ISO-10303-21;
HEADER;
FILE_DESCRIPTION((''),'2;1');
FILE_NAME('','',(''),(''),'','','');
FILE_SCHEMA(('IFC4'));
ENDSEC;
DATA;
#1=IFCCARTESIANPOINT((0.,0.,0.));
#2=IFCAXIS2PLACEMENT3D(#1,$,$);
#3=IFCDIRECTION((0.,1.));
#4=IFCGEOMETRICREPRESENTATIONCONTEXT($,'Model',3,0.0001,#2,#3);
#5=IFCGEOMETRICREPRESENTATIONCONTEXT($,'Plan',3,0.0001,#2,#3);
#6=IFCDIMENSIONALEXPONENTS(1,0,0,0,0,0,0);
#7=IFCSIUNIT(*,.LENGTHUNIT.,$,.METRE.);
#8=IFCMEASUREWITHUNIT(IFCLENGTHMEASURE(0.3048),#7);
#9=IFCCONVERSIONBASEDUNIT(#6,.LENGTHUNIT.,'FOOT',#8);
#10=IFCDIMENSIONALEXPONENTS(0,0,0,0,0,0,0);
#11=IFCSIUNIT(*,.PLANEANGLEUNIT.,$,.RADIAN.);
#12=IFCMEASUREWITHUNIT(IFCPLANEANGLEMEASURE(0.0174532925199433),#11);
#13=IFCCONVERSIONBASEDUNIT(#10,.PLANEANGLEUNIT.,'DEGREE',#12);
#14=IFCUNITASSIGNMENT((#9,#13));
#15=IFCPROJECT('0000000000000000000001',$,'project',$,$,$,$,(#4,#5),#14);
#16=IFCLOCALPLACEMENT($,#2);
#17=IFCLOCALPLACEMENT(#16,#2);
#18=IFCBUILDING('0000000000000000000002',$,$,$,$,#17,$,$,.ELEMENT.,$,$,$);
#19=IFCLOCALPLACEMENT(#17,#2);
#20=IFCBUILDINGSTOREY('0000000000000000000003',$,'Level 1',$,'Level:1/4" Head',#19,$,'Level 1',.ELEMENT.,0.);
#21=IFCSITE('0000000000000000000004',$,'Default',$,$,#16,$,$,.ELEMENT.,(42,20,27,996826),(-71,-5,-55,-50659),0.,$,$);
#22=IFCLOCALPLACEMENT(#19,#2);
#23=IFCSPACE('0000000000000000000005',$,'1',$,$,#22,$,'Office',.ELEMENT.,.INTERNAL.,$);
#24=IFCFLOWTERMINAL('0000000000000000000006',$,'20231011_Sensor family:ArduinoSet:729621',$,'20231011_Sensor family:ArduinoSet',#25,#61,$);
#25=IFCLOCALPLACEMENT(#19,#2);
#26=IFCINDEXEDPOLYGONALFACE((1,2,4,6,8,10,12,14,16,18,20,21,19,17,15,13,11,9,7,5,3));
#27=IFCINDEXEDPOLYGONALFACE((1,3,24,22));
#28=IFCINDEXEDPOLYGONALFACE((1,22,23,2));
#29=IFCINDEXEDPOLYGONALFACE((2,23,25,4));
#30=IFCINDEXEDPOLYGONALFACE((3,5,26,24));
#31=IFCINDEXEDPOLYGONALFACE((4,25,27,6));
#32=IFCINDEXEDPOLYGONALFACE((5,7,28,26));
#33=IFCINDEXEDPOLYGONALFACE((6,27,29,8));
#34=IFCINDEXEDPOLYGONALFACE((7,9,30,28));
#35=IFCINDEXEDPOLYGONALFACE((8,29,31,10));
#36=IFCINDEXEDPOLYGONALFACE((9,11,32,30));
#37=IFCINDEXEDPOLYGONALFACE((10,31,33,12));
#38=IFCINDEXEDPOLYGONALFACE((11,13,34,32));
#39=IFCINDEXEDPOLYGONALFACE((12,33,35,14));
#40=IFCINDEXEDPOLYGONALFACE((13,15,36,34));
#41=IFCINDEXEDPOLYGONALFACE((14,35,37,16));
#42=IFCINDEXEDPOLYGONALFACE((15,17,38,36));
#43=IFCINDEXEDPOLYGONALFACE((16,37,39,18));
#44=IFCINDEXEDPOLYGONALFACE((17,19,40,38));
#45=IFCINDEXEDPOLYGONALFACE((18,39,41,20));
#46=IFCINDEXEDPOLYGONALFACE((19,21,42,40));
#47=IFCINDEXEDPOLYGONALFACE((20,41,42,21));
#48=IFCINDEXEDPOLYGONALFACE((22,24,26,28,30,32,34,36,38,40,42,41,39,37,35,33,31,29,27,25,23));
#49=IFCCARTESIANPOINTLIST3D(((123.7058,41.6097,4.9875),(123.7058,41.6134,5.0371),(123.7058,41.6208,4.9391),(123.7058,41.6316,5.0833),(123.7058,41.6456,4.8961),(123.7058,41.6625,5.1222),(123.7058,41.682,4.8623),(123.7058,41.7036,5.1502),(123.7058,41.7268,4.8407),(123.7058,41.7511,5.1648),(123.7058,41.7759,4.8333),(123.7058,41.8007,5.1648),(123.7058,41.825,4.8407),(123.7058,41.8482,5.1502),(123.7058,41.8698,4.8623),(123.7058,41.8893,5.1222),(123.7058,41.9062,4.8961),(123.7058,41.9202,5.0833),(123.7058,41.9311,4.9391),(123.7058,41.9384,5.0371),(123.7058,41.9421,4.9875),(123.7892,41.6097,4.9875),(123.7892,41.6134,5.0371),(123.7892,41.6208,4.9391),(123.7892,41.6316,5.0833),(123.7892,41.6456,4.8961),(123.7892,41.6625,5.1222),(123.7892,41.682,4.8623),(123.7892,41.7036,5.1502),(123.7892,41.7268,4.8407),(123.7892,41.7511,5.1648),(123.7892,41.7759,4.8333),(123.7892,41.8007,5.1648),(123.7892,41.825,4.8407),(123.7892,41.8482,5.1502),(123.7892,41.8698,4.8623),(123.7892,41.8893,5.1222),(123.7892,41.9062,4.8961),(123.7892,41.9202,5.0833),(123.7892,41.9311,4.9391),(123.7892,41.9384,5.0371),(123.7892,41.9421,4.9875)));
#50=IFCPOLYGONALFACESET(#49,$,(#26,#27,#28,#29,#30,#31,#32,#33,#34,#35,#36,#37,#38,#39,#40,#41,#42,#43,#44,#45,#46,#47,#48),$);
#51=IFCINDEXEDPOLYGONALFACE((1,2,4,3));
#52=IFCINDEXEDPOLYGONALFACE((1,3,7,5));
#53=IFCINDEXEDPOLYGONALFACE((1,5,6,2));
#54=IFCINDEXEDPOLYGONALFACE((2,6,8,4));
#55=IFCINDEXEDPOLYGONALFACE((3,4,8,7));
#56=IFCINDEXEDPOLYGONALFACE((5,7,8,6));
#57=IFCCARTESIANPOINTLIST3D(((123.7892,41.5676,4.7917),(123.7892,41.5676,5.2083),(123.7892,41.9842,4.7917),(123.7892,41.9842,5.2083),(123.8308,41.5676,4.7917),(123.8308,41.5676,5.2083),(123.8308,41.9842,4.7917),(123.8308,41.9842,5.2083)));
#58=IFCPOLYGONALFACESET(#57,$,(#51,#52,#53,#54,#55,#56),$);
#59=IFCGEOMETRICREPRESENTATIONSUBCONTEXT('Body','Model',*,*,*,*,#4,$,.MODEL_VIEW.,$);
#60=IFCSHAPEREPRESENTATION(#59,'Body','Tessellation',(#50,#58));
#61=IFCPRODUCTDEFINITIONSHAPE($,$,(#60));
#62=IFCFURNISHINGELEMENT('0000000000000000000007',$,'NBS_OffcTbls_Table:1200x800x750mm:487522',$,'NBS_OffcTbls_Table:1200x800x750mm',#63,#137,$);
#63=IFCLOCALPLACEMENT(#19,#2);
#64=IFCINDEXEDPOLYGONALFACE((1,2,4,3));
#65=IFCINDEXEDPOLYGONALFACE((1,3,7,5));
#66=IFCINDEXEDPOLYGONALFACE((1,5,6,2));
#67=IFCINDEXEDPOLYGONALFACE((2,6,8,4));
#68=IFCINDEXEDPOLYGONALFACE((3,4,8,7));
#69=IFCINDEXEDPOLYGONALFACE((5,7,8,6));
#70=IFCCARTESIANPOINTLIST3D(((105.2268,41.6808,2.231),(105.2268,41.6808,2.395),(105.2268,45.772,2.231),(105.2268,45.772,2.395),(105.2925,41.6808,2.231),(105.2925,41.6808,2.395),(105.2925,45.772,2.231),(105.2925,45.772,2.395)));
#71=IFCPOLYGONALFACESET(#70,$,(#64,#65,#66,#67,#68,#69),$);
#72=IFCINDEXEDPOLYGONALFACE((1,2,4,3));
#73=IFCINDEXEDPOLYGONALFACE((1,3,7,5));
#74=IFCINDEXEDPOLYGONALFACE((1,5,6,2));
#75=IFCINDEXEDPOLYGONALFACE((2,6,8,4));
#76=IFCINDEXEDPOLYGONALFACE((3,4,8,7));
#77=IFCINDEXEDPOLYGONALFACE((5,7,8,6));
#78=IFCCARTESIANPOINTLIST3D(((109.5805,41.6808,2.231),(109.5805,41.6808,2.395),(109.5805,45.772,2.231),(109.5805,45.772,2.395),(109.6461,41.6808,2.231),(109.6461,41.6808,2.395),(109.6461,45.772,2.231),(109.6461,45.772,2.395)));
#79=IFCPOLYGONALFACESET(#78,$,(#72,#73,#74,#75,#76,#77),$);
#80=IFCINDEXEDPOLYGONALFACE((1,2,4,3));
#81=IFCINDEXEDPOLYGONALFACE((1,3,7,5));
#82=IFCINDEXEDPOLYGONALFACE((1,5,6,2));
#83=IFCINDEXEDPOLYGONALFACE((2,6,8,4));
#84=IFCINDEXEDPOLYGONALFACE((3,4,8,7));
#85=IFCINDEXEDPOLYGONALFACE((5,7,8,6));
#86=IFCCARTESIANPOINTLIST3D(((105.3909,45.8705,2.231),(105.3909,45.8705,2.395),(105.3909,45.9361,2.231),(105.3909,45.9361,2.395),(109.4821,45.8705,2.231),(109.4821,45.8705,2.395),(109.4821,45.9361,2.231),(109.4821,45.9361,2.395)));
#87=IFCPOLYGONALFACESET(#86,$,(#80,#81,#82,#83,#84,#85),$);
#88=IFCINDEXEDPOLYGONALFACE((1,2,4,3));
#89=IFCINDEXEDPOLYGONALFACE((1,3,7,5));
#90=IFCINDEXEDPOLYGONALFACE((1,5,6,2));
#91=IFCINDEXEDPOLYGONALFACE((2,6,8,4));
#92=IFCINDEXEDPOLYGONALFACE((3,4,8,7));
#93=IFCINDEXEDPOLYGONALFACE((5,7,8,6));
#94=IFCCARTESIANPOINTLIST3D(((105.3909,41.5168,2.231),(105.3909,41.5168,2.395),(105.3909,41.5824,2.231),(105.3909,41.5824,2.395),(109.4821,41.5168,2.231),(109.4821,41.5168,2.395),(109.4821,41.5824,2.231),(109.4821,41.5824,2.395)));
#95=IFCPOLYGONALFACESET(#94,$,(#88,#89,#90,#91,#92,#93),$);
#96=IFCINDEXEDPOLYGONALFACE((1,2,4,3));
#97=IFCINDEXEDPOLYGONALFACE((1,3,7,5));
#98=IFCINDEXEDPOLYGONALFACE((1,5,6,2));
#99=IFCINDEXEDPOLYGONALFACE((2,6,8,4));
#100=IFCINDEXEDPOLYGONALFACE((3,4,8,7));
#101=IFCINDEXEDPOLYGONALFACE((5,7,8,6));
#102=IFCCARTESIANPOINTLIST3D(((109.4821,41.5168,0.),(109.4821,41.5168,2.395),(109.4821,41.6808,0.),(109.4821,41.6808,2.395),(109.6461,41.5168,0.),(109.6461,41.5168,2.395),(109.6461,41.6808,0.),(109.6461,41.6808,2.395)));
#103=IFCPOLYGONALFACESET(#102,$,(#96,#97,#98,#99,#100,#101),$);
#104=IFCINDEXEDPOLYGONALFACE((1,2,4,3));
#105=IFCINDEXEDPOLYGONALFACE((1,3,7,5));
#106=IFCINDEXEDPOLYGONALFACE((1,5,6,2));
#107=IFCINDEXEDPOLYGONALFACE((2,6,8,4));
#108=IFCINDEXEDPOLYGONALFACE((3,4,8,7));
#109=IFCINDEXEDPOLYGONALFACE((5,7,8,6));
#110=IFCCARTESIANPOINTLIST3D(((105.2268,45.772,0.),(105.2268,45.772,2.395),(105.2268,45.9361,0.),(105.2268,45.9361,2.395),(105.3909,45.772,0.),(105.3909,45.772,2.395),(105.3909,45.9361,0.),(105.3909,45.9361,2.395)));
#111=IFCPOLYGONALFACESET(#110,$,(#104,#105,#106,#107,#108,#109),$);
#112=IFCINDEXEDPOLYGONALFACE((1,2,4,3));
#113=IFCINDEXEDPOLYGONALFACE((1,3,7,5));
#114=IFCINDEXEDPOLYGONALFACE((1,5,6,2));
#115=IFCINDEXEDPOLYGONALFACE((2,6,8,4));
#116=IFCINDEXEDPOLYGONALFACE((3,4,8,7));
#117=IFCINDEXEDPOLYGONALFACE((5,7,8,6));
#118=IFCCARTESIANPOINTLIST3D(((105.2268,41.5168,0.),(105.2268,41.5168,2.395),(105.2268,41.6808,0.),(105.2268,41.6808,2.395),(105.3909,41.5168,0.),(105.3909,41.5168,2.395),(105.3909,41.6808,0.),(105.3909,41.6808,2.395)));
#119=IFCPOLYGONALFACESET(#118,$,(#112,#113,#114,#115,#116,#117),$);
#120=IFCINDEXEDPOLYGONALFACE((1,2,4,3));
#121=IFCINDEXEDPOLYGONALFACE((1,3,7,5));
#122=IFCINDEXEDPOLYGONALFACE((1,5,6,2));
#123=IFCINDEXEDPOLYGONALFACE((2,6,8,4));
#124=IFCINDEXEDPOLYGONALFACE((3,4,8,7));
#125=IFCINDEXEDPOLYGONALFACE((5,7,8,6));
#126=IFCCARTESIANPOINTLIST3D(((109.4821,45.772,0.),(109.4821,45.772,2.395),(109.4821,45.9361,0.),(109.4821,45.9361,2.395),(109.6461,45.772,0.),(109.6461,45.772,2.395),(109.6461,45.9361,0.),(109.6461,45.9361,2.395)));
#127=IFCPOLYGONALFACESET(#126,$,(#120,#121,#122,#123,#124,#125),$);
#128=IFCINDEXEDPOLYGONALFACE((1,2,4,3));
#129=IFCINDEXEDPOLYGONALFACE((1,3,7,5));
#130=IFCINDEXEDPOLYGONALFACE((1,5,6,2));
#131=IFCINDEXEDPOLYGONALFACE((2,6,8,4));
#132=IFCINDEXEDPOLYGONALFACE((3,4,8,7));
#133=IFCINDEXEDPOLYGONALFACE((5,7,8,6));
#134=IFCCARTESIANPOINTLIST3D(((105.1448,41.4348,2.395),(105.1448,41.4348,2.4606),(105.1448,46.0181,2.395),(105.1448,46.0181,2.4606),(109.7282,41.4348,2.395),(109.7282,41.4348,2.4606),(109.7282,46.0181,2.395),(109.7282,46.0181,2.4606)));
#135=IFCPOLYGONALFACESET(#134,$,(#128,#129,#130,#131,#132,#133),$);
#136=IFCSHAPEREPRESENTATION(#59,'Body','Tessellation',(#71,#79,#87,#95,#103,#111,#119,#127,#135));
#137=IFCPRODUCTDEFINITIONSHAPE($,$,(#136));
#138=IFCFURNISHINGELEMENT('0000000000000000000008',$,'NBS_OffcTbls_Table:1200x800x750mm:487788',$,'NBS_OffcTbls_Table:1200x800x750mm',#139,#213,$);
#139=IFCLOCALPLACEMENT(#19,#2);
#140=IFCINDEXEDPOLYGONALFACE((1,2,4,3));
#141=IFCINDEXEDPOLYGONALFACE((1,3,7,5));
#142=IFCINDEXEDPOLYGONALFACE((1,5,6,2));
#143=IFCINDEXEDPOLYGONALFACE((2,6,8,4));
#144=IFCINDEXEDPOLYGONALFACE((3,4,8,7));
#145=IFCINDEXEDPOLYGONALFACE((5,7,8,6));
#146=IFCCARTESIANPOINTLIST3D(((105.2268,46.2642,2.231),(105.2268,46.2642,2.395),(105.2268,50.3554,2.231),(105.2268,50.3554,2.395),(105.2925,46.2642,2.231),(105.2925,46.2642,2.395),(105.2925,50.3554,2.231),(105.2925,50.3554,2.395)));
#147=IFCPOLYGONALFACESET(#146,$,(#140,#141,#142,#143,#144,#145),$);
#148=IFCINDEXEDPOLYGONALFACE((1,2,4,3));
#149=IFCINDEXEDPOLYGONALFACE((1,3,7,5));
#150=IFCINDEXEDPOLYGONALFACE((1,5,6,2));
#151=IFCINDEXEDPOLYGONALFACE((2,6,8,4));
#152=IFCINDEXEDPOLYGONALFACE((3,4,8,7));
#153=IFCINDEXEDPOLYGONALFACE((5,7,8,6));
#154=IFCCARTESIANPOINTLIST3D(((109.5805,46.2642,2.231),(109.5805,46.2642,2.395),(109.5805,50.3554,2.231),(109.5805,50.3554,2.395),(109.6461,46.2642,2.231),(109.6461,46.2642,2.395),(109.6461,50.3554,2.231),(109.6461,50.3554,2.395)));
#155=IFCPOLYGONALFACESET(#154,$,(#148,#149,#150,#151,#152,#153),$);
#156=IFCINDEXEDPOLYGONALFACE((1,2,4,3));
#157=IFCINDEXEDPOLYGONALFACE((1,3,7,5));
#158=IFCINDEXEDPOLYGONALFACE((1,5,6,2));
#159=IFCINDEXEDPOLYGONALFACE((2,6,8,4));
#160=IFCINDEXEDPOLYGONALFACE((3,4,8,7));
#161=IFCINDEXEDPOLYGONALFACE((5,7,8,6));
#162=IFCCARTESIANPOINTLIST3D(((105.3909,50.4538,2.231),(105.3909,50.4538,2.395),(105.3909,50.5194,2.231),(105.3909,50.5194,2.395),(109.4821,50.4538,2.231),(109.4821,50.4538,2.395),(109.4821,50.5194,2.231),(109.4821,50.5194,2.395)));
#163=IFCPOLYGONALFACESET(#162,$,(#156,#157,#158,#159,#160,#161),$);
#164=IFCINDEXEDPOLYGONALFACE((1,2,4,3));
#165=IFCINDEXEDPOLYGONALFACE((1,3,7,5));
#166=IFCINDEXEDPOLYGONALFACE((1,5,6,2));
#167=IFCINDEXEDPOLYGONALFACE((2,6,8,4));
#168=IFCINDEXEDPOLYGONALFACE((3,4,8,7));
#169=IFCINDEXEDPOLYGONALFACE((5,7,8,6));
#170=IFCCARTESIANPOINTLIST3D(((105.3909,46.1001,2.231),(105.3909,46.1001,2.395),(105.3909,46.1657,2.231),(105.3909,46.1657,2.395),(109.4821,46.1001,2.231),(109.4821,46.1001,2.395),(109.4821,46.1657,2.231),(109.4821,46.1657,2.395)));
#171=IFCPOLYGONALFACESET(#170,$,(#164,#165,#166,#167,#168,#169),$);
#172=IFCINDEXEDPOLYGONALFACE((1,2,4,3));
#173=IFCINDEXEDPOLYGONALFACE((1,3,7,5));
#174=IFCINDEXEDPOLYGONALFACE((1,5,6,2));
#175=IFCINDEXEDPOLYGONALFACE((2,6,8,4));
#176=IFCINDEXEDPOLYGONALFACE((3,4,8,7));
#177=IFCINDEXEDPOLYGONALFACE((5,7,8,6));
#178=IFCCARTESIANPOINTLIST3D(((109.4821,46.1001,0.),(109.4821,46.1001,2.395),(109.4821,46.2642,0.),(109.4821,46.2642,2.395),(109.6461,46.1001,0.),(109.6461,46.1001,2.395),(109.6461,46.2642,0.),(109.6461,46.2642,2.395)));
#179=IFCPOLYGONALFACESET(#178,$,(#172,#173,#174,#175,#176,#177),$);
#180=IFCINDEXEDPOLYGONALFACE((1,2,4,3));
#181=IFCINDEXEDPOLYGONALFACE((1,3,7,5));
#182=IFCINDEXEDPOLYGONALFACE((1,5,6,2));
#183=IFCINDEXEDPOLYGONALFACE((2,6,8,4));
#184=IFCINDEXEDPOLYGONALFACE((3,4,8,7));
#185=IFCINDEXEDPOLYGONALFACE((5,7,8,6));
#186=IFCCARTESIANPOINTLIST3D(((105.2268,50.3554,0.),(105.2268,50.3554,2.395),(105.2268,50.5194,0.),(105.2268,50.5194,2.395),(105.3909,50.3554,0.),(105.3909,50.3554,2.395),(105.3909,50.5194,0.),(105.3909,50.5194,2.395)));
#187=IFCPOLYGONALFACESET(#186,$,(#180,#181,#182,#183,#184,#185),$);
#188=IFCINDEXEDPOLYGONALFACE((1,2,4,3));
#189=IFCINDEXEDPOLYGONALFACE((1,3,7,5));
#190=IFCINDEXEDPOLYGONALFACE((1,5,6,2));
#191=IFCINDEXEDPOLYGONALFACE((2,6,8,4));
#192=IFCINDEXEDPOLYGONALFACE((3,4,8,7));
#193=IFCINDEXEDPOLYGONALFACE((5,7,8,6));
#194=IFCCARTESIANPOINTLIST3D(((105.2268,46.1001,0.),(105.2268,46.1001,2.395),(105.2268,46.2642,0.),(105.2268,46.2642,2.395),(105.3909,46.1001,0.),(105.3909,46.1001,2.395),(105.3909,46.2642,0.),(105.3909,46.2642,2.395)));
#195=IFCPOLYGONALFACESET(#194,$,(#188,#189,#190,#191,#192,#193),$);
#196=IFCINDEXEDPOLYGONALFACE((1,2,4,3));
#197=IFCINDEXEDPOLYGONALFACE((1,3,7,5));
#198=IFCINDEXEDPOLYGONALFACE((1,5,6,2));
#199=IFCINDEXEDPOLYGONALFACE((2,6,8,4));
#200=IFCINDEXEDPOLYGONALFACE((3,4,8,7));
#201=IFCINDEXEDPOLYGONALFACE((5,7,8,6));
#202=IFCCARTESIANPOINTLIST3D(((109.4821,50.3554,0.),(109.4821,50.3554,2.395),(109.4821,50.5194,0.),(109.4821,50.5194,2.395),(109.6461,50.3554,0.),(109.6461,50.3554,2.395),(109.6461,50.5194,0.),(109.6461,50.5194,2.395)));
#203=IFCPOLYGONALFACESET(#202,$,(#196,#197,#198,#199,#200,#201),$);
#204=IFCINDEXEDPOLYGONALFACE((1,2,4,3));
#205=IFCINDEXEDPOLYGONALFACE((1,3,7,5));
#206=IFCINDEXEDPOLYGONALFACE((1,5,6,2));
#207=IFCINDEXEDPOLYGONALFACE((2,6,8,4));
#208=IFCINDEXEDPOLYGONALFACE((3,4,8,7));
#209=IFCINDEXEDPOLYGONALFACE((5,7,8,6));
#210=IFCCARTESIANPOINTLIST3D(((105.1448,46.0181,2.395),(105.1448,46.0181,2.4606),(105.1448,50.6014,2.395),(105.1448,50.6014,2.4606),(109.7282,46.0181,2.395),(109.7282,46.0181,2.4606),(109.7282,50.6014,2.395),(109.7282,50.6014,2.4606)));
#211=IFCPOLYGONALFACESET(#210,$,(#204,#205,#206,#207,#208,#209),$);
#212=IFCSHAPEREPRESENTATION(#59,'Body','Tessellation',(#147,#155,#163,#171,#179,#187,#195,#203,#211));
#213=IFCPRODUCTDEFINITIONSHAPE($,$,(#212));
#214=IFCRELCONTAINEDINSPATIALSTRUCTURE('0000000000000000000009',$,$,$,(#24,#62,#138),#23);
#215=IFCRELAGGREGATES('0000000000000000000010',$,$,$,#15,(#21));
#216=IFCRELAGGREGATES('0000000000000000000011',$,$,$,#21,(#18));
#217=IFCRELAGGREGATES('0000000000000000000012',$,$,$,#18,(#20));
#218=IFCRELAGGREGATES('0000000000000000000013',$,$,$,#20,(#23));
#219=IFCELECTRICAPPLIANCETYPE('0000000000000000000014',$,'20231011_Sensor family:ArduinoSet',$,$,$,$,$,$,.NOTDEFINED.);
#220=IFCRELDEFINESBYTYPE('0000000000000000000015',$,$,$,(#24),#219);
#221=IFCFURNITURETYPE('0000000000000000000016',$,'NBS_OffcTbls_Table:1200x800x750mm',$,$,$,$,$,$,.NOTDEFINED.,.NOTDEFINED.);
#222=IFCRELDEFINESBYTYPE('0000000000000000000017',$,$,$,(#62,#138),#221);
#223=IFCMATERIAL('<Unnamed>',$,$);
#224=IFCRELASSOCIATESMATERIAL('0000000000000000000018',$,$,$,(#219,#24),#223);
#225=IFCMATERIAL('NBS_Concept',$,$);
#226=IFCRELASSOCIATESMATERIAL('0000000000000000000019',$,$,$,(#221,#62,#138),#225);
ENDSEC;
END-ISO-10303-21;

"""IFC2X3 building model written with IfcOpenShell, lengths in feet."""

from ifc_helpers import new_model, entity, si_unit, converted_unit, direction, frame, frame_2d, origin, origin_2d_with_axis, place, context, subcontext, project, spatial, rectangle, circle, extrude, source, transform, mapped, material, type_object, type_shapes, element, save


model = new_model("IFC2X3")

# Units and contexts
model_context = context("Model", 3, precision=0.0001, world=origin(), true_north=direction((0.0, 1.0)))
plan_context = context("Plan", 3, precision=0.0001, world=origin(), true_north=direction((0.0, 1.0)))
body_context = subcontext(model_context, "Body", "Model", "MODEL_VIEW")
ifc_project = project(units=[converted_unit("LENGTHUNIT", "FOOT", entity("IfcLengthMeasure", 0.3048), si_unit("LENGTHUNIT", "METRE"), dimensions=[1, 0, 0, 0, 0, 0, 0]), converted_unit("PLANEANGLEUNIT", "DEGREE", entity("IfcPlaneAngleMeasure", 0.0174532925199433), si_unit("PLANEANGLEUNIT", "RADIAN"), dimensions=[0, 0, 0, 0, 0, 0, 0])], contexts=[model_context, plan_context])

# Site, building, storey
site_placement = place(None, origin())
site = spatial("IfcSite", under=ifc_project, at=site_placement, Name="Default", CompositionType="ELEMENT", RefLatitude=(42, 20, 27, 996826), RefLongitude=(-71, -5, -55, -50659), RefElevation=0.0)
building_placement = place(site_placement, origin())
building = spatial("IfcBuilding", under=site, at=building_placement, CompositionType="ELEMENT")
storey_placement = place(building_placement, origin())
storey = spatial("IfcBuildingStorey", under=building, at=storey_placement, Name="Level 1", ObjectType="Level:1/4\" Head", LongName="Level 1", CompositionType="ELEMENT", Elevation=0.0)

# Shared definitions
ifc_material_1 = material(Name="<Unnamed>")

# Shared definitions
space_placement = place(storey_placement, origin())
space = spatial("IfcSpace", under=storey, at=space_placement, Name="1", LongName="Office", CompositionType="ELEMENT", InteriorOrExteriorSpace="INTERNAL")

# Flow terminal
electric_appliance_type = type_object("IfcElectricApplianceType", Name="20231011_Sensor family:ArduinoSet", PredefinedType="NOTDEFINED", material=ifc_material_1)
shared_shape_1 = source(origin(), body_context, "Body", "SweptSolid", [
    extrude(circle(Radius=0.1667, at=frame_2d((0.0, 0.0), x_axis=(1.0, 0.0))), frame((0.0417, 0.0, 0.0), z_axis=(1.0, 0.0, 0.0), x_axis=(0.0, 0.0, -1.0)), (0.0, 0.0, 1.0), 0.0833),
    extrude(rectangle(XDim=0.0417, YDim=0.4167, at=origin_2d_with_axis()), frame((0.0208, 0.0, -0.2083), z_axis=(0.0, 0.0, 1.0), x_axis=(-1.0, 0.0, 0.0)), (0.0, 0.0, 1.0), 0.4167),
])
type_shapes(electric_appliance_type, [shared_shape_1])
for number, where, z_axis, x_axis, name in (
    (1, (123.8308, 41.7759, 5.0), (0.0, 0.0, 1.0), (-1.0, 0.0, 0.0), "20231011_Sensor family:ArduinoSet:729621"),
):
    element("IfcFlowTerminal", number, at=place(space_placement, frame(where, z_axis=z_axis, x_axis=x_axis)), inside=space, type_object=electric_appliance_type, material=ifc_material_1, Name=name, ObjectType="20231011_Sensor family:ArduinoSet", context=body_context, shape_type="MappedRepresentation", body=[
        mapped(shared_shape_1, transform((0.0, 0.0, 0.0), scale=1.0)),
    ])

# Furnishing elements
ifc_material_2 = material(Name="NBS_Concept")
furniture_type_1 = type_object("IfcFurnitureType", Name="NBS_OffcTbls_Table:1200x800x750mm", AssemblyPlace="NOTDEFINED", material=ifc_material_2)
shared_shape_2 = source(origin(), body_context, "Body", "SweptSolid", [
    extrude(rectangle(XDim=0.0656, YDim=4.0912, at=frame_2d((0.0, 0.0), x_axis=(1.0, 0.0))), frame((-2.1768, 0.0, 2.231)), (0.0, 0.0, 1.0), 0.164),
    extrude(rectangle(XDim=4.0912, YDim=0.0656, at=frame_2d((0.0, 0.0), x_axis=(1.0, 0.0))), frame((2.1768, 0.0, 2.231), z_axis=(0.0, 0.0, 1.0), x_axis=(0.0, -1.0, 0.0)), (0.0, 0.0, 1.0), 0.164),
    extrude(rectangle(XDim=4.0912, YDim=0.0656, at=origin_2d_with_axis()), frame((0.0, 2.1768, 2.231), z_axis=(0.0, 0.0, 1.0), x_axis=(-1.0, 0.0, 0.0)), (0.0, 0.0, 1.0), 0.164),
    extrude(rectangle(XDim=4.0912, YDim=0.0656, at=origin_2d_with_axis()), frame((0.0, -2.1768, 2.231)), (0.0, 0.0, 1.0), 0.164),
    extrude(rectangle(XDim=0.164, YDim=0.164, at=origin_2d_with_axis()), frame((2.1276, -2.1276, 0.0), z_axis=(0.0, 0.0, 1.0), x_axis=(-1.0, 0.0, 0.0)), (0.0, 0.0, 1.0), 2.395),
    extrude(rectangle(XDim=0.164, YDim=0.164, at=frame_2d((0.0, 0.0), x_axis=(1.0, 0.0))), frame((-2.1276, 2.1276, 0.0), z_axis=(0.0, 0.0, 1.0), x_axis=(-1.0, 0.0, 0.0)), (0.0, 0.0, 1.0), 2.395),
    extrude(rectangle(XDim=0.164, YDim=0.164, at=origin_2d_with_axis()), frame((-2.1276, -2.1276, 0.0), z_axis=(0.0, 0.0, 1.0), x_axis=(-1.0, 0.0, 0.0)), (0.0, 0.0, 1.0), 2.395),
    extrude(rectangle(XDim=0.164, YDim=0.164, at=frame_2d((0.0, 0.0), x_axis=(1.0, 0.0))), frame((2.1276, 2.1276, 0.0)), (0.0, 0.0, 1.0), 2.395),
    extrude(rectangle(XDim=4.5833, YDim=4.5833, at=origin_2d_with_axis()), frame((0.0, 0.0, 2.395)), (0.0, 0.0, 1.0), 0.0656),
])
type_shapes(furniture_type_1, [shared_shape_2])
for number, where, name in (
    (2, (107.4365, 43.7264, 0.0), "NBS_OffcTbls_Table:1200x800x750mm:487522"),
    (3, (107.4365, 48.3098, 0.0), "NBS_OffcTbls_Table:1200x800x750mm:487788"),
):
    element("IfcFurnishingElement", number, at=place(space_placement, frame(where)), inside=space, type_object=furniture_type_1, material=ifc_material_2, Name=name, ObjectType="NBS_OffcTbls_Table:1200x800x750mm", context=body_context, shape_type="MappedRepresentation", body=[
        mapped(shared_shape_2, transform((0.0, 0.0, 0.0), scale=1.0)),
    ])

save(model, "model.ifc")
